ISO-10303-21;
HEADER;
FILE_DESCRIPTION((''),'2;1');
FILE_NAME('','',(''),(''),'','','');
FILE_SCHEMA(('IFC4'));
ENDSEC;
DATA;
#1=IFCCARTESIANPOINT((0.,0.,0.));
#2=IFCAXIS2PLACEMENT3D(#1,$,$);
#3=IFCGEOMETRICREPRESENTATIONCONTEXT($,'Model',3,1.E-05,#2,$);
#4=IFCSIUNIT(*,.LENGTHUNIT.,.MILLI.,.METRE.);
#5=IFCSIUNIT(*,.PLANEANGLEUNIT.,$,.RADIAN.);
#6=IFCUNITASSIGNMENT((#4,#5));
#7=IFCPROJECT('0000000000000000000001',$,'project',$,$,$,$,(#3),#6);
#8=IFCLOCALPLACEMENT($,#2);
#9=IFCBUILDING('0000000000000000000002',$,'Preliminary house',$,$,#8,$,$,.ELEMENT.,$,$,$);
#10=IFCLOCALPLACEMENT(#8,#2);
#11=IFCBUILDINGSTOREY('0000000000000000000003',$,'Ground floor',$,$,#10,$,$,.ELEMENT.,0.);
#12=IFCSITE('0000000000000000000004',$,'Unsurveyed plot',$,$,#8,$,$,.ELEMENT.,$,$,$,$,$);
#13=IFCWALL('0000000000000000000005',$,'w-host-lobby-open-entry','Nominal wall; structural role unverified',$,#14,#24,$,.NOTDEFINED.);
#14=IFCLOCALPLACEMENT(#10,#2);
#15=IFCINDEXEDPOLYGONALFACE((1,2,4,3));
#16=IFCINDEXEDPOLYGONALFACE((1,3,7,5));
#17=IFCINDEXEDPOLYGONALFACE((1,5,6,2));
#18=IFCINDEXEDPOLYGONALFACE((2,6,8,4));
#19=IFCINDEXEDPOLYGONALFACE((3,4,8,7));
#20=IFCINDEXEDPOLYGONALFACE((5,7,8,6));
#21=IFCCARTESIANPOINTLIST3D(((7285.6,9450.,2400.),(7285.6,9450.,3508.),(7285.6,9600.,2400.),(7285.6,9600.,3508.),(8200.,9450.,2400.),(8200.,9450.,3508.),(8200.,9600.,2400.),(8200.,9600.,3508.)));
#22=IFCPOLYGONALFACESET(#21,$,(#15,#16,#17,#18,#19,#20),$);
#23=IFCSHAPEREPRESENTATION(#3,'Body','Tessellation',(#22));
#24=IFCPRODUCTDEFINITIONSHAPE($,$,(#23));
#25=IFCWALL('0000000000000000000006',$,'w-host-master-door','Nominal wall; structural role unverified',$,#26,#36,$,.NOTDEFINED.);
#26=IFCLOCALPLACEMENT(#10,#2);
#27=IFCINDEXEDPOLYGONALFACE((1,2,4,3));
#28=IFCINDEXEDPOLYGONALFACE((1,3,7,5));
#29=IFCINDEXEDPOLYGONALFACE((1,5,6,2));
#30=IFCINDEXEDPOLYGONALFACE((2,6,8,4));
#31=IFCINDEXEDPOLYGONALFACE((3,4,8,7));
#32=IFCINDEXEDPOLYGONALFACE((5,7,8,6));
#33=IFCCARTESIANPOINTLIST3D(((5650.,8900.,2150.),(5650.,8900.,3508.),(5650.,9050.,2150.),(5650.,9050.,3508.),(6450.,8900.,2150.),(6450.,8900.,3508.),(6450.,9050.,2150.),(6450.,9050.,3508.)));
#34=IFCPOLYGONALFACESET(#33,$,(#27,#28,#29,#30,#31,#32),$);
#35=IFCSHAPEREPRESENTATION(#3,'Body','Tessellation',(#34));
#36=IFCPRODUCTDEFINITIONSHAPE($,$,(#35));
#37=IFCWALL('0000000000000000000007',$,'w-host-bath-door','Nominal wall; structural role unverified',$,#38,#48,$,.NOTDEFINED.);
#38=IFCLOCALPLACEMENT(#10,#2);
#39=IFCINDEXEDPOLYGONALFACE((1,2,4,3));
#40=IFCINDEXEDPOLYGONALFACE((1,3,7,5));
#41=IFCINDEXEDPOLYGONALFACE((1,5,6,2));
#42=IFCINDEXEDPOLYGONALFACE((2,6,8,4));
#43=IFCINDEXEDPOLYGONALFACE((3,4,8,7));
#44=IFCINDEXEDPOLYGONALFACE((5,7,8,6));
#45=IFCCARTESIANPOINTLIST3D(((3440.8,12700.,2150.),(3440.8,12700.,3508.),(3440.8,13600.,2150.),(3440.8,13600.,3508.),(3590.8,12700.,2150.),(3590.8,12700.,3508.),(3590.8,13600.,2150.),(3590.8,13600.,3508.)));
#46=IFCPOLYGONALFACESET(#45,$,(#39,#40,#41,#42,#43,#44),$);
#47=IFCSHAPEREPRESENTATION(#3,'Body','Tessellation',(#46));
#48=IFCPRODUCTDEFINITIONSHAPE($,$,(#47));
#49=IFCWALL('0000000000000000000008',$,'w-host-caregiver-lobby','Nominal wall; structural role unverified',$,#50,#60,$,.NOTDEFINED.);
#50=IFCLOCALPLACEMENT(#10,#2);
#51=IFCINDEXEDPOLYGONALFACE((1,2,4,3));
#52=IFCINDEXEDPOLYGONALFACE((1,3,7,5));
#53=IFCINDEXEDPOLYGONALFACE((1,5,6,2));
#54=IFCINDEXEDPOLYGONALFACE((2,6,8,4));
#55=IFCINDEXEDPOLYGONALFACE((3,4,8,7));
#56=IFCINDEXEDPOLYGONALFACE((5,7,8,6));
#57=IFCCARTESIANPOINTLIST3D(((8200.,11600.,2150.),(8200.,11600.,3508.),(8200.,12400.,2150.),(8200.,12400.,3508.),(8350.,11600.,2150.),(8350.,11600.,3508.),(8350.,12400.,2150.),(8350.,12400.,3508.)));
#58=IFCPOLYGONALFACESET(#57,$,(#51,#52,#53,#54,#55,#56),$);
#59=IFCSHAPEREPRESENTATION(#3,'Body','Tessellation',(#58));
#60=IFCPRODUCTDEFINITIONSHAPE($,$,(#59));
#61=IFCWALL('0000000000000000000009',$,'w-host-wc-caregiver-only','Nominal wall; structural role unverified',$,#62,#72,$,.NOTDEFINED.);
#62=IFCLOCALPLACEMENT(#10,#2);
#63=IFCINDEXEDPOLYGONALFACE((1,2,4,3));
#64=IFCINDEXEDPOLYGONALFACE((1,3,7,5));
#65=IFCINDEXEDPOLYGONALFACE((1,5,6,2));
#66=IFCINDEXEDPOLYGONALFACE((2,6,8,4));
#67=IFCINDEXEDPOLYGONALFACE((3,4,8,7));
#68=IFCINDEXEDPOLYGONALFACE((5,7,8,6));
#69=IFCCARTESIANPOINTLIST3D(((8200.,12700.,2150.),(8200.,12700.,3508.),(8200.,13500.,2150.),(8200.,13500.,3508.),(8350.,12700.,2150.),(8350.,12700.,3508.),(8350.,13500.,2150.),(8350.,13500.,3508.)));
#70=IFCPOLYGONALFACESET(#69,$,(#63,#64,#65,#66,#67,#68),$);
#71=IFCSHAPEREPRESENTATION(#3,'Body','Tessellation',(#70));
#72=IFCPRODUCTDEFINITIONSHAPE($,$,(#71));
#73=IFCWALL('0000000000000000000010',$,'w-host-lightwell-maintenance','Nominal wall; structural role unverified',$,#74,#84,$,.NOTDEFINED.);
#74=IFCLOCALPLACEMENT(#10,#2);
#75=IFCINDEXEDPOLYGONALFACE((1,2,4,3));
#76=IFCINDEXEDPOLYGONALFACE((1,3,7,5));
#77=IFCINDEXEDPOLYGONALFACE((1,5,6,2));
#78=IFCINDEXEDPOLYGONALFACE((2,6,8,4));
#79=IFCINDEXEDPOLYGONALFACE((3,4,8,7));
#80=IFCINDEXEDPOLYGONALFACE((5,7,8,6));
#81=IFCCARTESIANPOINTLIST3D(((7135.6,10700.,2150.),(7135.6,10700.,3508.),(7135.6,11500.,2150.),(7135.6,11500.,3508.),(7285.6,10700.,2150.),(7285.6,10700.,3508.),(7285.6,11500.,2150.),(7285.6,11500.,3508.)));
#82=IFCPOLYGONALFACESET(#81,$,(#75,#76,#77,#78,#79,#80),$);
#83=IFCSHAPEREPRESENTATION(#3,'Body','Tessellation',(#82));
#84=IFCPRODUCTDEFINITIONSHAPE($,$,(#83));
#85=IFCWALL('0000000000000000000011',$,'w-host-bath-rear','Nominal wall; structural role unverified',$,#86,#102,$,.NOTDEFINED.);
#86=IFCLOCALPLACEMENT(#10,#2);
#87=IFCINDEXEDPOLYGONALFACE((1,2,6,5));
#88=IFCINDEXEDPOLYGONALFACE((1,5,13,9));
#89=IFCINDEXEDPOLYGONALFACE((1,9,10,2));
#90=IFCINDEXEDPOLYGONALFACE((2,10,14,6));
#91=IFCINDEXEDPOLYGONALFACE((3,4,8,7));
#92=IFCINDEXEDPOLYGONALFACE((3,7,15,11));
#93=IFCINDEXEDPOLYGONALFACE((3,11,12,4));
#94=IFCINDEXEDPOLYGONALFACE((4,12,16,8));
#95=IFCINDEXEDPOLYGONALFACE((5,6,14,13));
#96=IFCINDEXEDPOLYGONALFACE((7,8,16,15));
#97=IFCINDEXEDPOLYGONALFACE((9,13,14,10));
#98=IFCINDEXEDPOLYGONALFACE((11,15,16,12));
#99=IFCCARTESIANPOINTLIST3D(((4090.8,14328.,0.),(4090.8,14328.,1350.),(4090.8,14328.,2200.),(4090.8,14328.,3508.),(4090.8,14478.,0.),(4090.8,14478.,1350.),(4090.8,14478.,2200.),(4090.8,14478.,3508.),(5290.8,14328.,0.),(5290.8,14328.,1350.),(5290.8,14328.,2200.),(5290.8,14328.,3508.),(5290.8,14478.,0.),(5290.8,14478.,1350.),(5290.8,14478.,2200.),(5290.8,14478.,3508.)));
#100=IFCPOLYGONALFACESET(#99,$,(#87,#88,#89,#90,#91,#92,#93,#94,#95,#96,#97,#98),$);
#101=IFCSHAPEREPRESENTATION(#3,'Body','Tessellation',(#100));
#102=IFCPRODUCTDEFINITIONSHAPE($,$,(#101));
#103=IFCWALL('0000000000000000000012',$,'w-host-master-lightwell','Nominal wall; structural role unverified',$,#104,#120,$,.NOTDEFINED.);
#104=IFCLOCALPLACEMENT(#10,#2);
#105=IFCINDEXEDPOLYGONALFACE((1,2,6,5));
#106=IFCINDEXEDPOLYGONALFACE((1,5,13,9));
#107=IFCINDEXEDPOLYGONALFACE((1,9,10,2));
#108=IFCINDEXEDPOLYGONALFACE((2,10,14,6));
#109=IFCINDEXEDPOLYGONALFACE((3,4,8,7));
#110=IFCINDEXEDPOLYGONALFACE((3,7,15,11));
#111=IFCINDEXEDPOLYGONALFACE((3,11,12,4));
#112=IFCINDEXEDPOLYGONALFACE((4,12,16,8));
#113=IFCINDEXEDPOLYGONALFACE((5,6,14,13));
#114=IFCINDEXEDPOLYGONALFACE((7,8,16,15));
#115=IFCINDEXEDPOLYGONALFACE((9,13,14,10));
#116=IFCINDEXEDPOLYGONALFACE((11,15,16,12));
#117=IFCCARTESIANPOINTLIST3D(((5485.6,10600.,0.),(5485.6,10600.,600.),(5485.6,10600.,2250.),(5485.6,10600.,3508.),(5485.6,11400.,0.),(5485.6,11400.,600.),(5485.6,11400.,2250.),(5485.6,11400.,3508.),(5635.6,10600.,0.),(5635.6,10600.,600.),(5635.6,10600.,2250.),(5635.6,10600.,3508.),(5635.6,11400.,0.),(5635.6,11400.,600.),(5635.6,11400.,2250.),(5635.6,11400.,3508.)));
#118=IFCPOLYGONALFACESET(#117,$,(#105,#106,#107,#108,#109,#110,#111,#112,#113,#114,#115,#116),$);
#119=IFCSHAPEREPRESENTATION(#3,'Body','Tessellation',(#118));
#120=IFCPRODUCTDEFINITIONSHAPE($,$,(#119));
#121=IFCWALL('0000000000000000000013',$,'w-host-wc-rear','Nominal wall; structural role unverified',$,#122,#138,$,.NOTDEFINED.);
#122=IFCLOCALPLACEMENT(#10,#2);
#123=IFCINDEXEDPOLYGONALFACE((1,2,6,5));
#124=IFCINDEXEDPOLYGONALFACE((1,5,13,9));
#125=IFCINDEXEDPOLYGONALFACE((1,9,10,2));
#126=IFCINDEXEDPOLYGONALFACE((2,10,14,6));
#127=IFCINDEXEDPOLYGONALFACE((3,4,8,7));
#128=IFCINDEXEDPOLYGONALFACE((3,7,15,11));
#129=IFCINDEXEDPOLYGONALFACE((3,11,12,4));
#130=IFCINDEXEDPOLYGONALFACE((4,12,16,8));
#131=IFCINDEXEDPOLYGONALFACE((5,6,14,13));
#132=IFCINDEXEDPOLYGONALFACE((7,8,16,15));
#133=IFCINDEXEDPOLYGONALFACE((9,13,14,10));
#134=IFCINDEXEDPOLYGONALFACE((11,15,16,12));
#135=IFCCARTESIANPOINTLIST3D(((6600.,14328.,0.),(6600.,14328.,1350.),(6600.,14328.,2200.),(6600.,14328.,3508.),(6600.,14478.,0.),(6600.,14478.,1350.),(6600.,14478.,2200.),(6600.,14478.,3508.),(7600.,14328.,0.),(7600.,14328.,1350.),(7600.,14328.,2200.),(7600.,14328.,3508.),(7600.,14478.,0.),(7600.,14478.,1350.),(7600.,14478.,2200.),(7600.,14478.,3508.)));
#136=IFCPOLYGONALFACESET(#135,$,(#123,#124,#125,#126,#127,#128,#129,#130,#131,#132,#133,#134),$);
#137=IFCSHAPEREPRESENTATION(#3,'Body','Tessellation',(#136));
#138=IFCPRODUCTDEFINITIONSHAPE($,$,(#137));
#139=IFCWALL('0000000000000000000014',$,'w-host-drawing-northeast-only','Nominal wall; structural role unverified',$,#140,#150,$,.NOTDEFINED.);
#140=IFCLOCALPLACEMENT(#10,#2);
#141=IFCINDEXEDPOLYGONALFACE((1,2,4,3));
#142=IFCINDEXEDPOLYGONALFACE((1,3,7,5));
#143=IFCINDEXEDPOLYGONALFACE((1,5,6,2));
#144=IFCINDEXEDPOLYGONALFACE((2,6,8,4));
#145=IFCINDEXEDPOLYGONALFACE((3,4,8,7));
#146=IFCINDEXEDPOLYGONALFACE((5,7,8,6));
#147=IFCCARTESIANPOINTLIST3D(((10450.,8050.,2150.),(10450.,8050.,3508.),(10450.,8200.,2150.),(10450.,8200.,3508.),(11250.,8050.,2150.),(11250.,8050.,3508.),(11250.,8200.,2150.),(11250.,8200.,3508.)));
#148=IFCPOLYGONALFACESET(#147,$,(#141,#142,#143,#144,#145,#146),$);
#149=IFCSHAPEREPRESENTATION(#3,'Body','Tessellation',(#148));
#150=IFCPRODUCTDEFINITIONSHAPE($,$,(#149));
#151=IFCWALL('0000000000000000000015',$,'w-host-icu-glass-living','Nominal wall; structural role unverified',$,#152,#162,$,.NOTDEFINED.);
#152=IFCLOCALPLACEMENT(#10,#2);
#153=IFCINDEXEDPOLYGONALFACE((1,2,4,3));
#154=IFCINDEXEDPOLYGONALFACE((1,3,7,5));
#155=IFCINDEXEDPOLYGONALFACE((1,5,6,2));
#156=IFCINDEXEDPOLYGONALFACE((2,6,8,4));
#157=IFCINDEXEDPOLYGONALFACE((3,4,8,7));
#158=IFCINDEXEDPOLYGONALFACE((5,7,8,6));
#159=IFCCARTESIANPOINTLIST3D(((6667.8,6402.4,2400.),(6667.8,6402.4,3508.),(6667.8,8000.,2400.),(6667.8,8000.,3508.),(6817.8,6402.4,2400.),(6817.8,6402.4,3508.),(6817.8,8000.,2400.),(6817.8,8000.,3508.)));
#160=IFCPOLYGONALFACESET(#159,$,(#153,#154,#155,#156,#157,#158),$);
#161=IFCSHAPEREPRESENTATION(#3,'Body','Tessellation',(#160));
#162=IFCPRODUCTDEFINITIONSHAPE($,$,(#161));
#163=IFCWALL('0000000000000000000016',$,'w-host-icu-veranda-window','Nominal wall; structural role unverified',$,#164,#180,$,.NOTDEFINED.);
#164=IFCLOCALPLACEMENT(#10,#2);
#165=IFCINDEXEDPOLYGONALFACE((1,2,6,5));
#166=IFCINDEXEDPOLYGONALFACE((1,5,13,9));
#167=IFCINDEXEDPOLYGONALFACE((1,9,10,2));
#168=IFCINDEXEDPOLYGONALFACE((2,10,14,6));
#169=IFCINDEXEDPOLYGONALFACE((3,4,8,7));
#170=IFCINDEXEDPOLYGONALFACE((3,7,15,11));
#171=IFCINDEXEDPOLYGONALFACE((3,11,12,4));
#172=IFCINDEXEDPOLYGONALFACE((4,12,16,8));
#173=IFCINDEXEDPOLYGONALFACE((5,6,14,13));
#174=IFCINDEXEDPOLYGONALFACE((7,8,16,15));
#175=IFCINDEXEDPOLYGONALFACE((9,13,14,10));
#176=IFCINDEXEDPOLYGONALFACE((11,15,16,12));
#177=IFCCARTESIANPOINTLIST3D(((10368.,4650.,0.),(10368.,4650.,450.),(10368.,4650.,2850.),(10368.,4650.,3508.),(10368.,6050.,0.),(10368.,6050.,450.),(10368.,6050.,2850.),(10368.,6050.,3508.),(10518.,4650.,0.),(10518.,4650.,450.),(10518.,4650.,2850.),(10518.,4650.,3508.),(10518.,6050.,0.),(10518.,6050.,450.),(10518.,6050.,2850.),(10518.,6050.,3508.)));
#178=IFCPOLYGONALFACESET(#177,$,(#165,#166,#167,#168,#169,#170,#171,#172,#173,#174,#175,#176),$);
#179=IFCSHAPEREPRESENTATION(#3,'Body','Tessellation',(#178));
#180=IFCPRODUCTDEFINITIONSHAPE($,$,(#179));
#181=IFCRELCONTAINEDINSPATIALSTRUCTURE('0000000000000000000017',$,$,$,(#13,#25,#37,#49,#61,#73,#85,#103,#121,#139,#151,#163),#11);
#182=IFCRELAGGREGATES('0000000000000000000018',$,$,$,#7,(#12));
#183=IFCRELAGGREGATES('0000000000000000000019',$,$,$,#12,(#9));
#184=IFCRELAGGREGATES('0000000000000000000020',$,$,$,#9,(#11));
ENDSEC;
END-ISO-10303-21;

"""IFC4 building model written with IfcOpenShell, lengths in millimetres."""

from ifc_helpers import new_model, si_unit, frame, origin, place, context, project, spatial, polyline, outline, extrude, element, save


model = new_model("IFC4")

# Units and contexts
model_context = context("Model", 3, precision=1e-05, world=origin())
ifc_project = project(units=[si_unit("LENGTHUNIT", "METRE", prefix="MILLI"), si_unit("PLANEANGLEUNIT", "RADIAN")], contexts=[model_context])

# Site, building, storey
placement_1 = place(None, origin())
site = spatial("IfcSite", under=ifc_project, at=placement_1, Name="Unsurveyed plot", CompositionType="ELEMENT")
building = spatial("IfcBuilding", under=site, at=placement_1, Name="Preliminary house", CompositionType="ELEMENT")
placement_2 = place(placement_1, origin())
storey = spatial("IfcBuildingStorey", under=building, at=placement_2, Name="Ground floor", CompositionType="ELEMENT", Elevation=0.0)

# Walls, openings
wall_1 = element("IfcWall", 1, at=placement_2, inside=storey, Name="w-host-lobby-open-entry", Description="Nominal wall; structural role unverified", PredefinedType="NOTDEFINED", context=model_context, shape_type="SweptSolid", body=[
    extrude(outline(polyline([(7285.6, 9450.0), (8200.0, 9450.0), (8200.0, 9600.0), (7285.6, 9600.0), (7285.6, 9450.0)])), origin(), (0.0, 0.0, 1.0), 3508.0),
])
element("IfcOpeningElement", 2, at=placement_2, cuts=wall_1, PredefinedType="OPENING", context=model_context, shape_type="SweptSolid", body=[
    extrude(outline(polyline([(7285.6, 9075.0), (8200.0, 9075.0), (8200.0, 9975.0), (7285.6, 9975.0), (7285.6, 9075.0)])), origin(), (0.0, 0.0, 1.0), 2400.0),
])
wall_2 = element("IfcWall", 3, at=placement_2, inside=storey, Name="w-host-master-door", Description="Nominal wall; structural role unverified", PredefinedType="NOTDEFINED", context=model_context, shape_type="SweptSolid", body=[
    extrude(outline(polyline([(5650.0, 8900.0), (6450.0, 8900.0), (6450.0, 9050.0), (5650.0, 9050.0), (5650.0, 8900.0)])), origin(), (0.0, 0.0, 1.0), 3508.0),
])
element("IfcOpeningElement", 4, at=placement_2, cuts=wall_2, PredefinedType="OPENING", context=model_context, shape_type="SweptSolid", body=[
    extrude(outline(polyline([(5650.0, 8525.0), (6450.0, 8525.0), (6450.0, 9425.0), (5650.0, 9425.0), (5650.0, 8525.0)])), origin(), (0.0, 0.0, 1.0), 2150.0),
])
wall_3 = element("IfcWall", 5, at=placement_2, inside=storey, Name="w-host-bath-door", Description="Nominal wall; structural role unverified", PredefinedType="NOTDEFINED", context=model_context, shape_type="SweptSolid", body=[
    extrude(outline(polyline([(3590.8, 12700.0), (3590.8, 13600.0), (3440.8, 13600.0), (3440.8, 12700.0), (3590.8, 12700.0)])), origin(), (0.0, 0.0, 1.0), 3508.0),
])
element("IfcOpeningElement", 6, at=placement_2, cuts=wall_3, PredefinedType="OPENING", context=model_context, shape_type="SweptSolid", body=[
    extrude(outline(polyline([(3965.8, 12700.0), (3965.8, 13600.0), (3065.8, 13600.0), (3065.8, 12700.0), (3965.8, 12700.0)])), origin(), (0.0, 0.0, 1.0), 2150.0),
])
wall_4 = element("IfcWall", 7, at=placement_2, inside=storey, Name="w-host-caregiver-lobby", Description="Nominal wall; structural role unverified", PredefinedType="NOTDEFINED", context=model_context, shape_type="SweptSolid", body=[
    extrude(outline(polyline([(8350.0, 11600.0), (8350.0, 12400.0), (8200.0, 12400.0), (8200.0, 11600.0), (8350.0, 11600.0)])), origin(), (0.0, 0.0, 1.0), 3508.0),
])
element("IfcOpeningElement", 8, at=placement_2, cuts=wall_4, PredefinedType="OPENING", context=model_context, shape_type="SweptSolid", body=[
    extrude(outline(polyline([(8725.0, 11600.0), (8725.0, 12400.0), (7825.0, 12400.0), (7825.0, 11600.0), (8725.0, 11600.0)])), origin(), (0.0, 0.0, 1.0), 2150.0),
])
wall_5 = element("IfcWall", 9, at=placement_2, inside=storey, Name="w-host-wc-caregiver-only", Description="Nominal wall; structural role unverified", PredefinedType="NOTDEFINED", context=model_context, shape_type="SweptSolid", body=[
    extrude(outline(polyline([(8350.0, 12700.0), (8350.0, 13500.0), (8200.0, 13500.0), (8200.0, 12700.0), (8350.0, 12700.0)])), origin(), (0.0, 0.0, 1.0), 3508.0),
])
element("IfcOpeningElement", 10, at=placement_2, cuts=wall_5, PredefinedType="OPENING", context=model_context, shape_type="SweptSolid", body=[
    extrude(outline(polyline([(8725.0, 12700.0), (8725.0, 13500.0), (7825.0, 13500.0), (7825.0, 12700.0), (8725.0, 12700.0)])), origin(), (0.0, 0.0, 1.0), 2150.0),
])
wall_6 = element("IfcWall", 11, at=placement_2, inside=storey, Name="w-host-lightwell-maintenance", Description="Nominal wall; structural role unverified", PredefinedType="NOTDEFINED", context=model_context, shape_type="SweptSolid", body=[
    extrude(outline(polyline([(7285.6, 10700.0), (7285.6, 11500.0), (7135.6, 11500.0), (7135.6, 10700.0), (7285.6, 10700.0)])), origin(), (0.0, 0.0, 1.0), 3508.0),
])
element("IfcOpeningElement", 12, at=placement_2, cuts=wall_6, PredefinedType="OPENING", context=model_context, shape_type="SweptSolid", body=[
    extrude(outline(polyline([(7660.6, 10700.0), (7660.6, 11500.0), (6760.6, 11500.0), (6760.6, 10700.0), (7660.6, 10700.0)])), origin(), (0.0, 0.0, 1.0), 2150.0),
])
wall_7 = element("IfcWall", 13, at=placement_2, inside=storey, Name="w-host-bath-rear", Description="Nominal wall; structural role unverified", PredefinedType="NOTDEFINED", context=model_context, shape_type="SweptSolid", body=[
    extrude(outline(polyline([(4090.8, 14328.0), (5290.8, 14328.0), (5290.8, 14478.0), (4090.8, 14478.0), (4090.8, 14328.0)])), origin(), (0.0, 0.0, 1.0), 3508.0),
])
element("IfcOpeningElement", 14, at=placement_2, cuts=wall_7, PredefinedType="OPENING", context=model_context, shape_type="SweptSolid", body=[
    extrude(outline(polyline([(4090.8, 13953.0), (5290.8, 13953.0), (5290.8, 14853.0), (4090.8, 14853.0), (4090.8, 13953.0)])), frame((0.0, 0.0, 1350.0)), (0.0, 0.0, 1.0), 850.0),
])
wall_8 = element("IfcWall", 15, at=placement_2, inside=storey, Name="w-host-master-lightwell", Description="Nominal wall; structural role unverified", PredefinedType="NOTDEFINED", context=model_context, shape_type="SweptSolid", body=[
    extrude(outline(polyline([(5635.6, 10600.0), (5635.6, 11400.0), (5485.6, 11400.0), (5485.6, 10600.0), (5635.6, 10600.0)])), origin(), (0.0, 0.0, 1.0), 3508.0),
])
element("IfcOpeningElement", 16, at=placement_2, cuts=wall_8, PredefinedType="OPENING", context=model_context, shape_type="SweptSolid", body=[
    extrude(outline(polyline([(6010.6, 10600.0), (6010.6, 11400.0), (5110.6, 11400.0), (5110.6, 10600.0), (6010.6, 10600.0)])), frame((0.0, 0.0, 600.0)), (0.0, 0.0, 1.0), 1650.0),
])
wall_9 = element("IfcWall", 17, at=placement_2, inside=storey, Name="w-host-wc-rear", Description="Nominal wall; structural role unverified", PredefinedType="NOTDEFINED", context=model_context, shape_type="SweptSolid", body=[
    extrude(outline(polyline([(6600.0, 14328.0), (7600.0, 14328.0), (7600.0, 14478.0), (6600.0, 14478.0), (6600.0, 14328.0)])), origin(), (0.0, 0.0, 1.0), 3508.0),
])
element("IfcOpeningElement", 18, at=placement_2, cuts=wall_9, PredefinedType="OPENING", context=model_context, shape_type="SweptSolid", body=[
    extrude(outline(polyline([(6600.0, 13953.0), (7600.0, 13953.0), (7600.0, 14853.0), (6600.0, 14853.0), (6600.0, 13953.0)])), frame((0.0, 0.0, 1350.0)), (0.0, 0.0, 1.0), 850.0),
])
wall_10 = element("IfcWall", 19, at=placement_2, inside=storey, Name="w-host-drawing-northeast-only", Description="Nominal wall; structural role unverified", PredefinedType="NOTDEFINED", context=model_context, shape_type="SweptSolid", body=[
    extrude(outline(polyline([(10450.0, 8050.0), (11250.0, 8050.0), (11250.0, 8200.0), (10450.0, 8200.0), (10450.0, 8050.0)])), origin(), (0.0, 0.0, 1.0), 3508.0),
])
element("IfcOpeningElement", 20, at=placement_2, cuts=wall_10, PredefinedType="OPENING", context=model_context, shape_type="SweptSolid", body=[
    extrude(outline(polyline([(10450.0, 7675.0), (11250.0, 7675.0), (11250.0, 8575.0), (10450.0, 8575.0), (10450.0, 7675.0)])), origin(), (0.0, 0.0, 1.0), 2150.0),
])
wall_11 = element("IfcWall", 21, at=placement_2, inside=storey, Name="w-host-icu-glass-living", Description="Nominal wall; structural role unverified", PredefinedType="NOTDEFINED", context=model_context, shape_type="SweptSolid", body=[
    extrude(outline(polyline([(6817.8, 6402.4), (6817.8, 8000.0), (6667.8, 8000.0), (6667.8, 6402.4), (6817.8, 6402.4)])), origin(), (0.0, 0.0, 1.0), 3508.0),
])
element("IfcOpeningElement", 22, at=placement_2, cuts=wall_11, PredefinedType="OPENING", context=model_context, shape_type="SweptSolid", body=[
    extrude(outline(polyline([(7192.8, 6402.4), (7192.8, 8000.0), (6292.8, 8000.0), (6292.8, 6402.4), (7192.8, 6402.4)])), origin(), (0.0, 0.0, 1.0), 2400.0),
])
wall_12 = element("IfcWall", 23, at=placement_2, inside=storey, Name="w-host-icu-veranda-window", Description="Nominal wall; structural role unverified", PredefinedType="NOTDEFINED", context=model_context, shape_type="SweptSolid", body=[
    extrude(outline(polyline([(10518.0, 4650.0), (10518.0, 6050.0), (10368.0, 6050.0), (10368.0, 4650.0), (10518.0, 4650.0)])), origin(), (0.0, 0.0, 1.0), 3508.0),
])
element("IfcOpeningElement", 24, at=placement_2, cuts=wall_12, PredefinedType="OPENING", context=model_context, shape_type="SweptSolid", body=[
    extrude(outline(polyline([(10893.0, 4650.0), (10893.0, 6050.0), (9993.0, 6050.0), (9993.0, 4650.0), (10893.0, 4650.0)])), frame((0.0, 0.0, 450.0)), (0.0, 0.0, 1.0), 2400.0),
])

save(model, "model.ifc")
